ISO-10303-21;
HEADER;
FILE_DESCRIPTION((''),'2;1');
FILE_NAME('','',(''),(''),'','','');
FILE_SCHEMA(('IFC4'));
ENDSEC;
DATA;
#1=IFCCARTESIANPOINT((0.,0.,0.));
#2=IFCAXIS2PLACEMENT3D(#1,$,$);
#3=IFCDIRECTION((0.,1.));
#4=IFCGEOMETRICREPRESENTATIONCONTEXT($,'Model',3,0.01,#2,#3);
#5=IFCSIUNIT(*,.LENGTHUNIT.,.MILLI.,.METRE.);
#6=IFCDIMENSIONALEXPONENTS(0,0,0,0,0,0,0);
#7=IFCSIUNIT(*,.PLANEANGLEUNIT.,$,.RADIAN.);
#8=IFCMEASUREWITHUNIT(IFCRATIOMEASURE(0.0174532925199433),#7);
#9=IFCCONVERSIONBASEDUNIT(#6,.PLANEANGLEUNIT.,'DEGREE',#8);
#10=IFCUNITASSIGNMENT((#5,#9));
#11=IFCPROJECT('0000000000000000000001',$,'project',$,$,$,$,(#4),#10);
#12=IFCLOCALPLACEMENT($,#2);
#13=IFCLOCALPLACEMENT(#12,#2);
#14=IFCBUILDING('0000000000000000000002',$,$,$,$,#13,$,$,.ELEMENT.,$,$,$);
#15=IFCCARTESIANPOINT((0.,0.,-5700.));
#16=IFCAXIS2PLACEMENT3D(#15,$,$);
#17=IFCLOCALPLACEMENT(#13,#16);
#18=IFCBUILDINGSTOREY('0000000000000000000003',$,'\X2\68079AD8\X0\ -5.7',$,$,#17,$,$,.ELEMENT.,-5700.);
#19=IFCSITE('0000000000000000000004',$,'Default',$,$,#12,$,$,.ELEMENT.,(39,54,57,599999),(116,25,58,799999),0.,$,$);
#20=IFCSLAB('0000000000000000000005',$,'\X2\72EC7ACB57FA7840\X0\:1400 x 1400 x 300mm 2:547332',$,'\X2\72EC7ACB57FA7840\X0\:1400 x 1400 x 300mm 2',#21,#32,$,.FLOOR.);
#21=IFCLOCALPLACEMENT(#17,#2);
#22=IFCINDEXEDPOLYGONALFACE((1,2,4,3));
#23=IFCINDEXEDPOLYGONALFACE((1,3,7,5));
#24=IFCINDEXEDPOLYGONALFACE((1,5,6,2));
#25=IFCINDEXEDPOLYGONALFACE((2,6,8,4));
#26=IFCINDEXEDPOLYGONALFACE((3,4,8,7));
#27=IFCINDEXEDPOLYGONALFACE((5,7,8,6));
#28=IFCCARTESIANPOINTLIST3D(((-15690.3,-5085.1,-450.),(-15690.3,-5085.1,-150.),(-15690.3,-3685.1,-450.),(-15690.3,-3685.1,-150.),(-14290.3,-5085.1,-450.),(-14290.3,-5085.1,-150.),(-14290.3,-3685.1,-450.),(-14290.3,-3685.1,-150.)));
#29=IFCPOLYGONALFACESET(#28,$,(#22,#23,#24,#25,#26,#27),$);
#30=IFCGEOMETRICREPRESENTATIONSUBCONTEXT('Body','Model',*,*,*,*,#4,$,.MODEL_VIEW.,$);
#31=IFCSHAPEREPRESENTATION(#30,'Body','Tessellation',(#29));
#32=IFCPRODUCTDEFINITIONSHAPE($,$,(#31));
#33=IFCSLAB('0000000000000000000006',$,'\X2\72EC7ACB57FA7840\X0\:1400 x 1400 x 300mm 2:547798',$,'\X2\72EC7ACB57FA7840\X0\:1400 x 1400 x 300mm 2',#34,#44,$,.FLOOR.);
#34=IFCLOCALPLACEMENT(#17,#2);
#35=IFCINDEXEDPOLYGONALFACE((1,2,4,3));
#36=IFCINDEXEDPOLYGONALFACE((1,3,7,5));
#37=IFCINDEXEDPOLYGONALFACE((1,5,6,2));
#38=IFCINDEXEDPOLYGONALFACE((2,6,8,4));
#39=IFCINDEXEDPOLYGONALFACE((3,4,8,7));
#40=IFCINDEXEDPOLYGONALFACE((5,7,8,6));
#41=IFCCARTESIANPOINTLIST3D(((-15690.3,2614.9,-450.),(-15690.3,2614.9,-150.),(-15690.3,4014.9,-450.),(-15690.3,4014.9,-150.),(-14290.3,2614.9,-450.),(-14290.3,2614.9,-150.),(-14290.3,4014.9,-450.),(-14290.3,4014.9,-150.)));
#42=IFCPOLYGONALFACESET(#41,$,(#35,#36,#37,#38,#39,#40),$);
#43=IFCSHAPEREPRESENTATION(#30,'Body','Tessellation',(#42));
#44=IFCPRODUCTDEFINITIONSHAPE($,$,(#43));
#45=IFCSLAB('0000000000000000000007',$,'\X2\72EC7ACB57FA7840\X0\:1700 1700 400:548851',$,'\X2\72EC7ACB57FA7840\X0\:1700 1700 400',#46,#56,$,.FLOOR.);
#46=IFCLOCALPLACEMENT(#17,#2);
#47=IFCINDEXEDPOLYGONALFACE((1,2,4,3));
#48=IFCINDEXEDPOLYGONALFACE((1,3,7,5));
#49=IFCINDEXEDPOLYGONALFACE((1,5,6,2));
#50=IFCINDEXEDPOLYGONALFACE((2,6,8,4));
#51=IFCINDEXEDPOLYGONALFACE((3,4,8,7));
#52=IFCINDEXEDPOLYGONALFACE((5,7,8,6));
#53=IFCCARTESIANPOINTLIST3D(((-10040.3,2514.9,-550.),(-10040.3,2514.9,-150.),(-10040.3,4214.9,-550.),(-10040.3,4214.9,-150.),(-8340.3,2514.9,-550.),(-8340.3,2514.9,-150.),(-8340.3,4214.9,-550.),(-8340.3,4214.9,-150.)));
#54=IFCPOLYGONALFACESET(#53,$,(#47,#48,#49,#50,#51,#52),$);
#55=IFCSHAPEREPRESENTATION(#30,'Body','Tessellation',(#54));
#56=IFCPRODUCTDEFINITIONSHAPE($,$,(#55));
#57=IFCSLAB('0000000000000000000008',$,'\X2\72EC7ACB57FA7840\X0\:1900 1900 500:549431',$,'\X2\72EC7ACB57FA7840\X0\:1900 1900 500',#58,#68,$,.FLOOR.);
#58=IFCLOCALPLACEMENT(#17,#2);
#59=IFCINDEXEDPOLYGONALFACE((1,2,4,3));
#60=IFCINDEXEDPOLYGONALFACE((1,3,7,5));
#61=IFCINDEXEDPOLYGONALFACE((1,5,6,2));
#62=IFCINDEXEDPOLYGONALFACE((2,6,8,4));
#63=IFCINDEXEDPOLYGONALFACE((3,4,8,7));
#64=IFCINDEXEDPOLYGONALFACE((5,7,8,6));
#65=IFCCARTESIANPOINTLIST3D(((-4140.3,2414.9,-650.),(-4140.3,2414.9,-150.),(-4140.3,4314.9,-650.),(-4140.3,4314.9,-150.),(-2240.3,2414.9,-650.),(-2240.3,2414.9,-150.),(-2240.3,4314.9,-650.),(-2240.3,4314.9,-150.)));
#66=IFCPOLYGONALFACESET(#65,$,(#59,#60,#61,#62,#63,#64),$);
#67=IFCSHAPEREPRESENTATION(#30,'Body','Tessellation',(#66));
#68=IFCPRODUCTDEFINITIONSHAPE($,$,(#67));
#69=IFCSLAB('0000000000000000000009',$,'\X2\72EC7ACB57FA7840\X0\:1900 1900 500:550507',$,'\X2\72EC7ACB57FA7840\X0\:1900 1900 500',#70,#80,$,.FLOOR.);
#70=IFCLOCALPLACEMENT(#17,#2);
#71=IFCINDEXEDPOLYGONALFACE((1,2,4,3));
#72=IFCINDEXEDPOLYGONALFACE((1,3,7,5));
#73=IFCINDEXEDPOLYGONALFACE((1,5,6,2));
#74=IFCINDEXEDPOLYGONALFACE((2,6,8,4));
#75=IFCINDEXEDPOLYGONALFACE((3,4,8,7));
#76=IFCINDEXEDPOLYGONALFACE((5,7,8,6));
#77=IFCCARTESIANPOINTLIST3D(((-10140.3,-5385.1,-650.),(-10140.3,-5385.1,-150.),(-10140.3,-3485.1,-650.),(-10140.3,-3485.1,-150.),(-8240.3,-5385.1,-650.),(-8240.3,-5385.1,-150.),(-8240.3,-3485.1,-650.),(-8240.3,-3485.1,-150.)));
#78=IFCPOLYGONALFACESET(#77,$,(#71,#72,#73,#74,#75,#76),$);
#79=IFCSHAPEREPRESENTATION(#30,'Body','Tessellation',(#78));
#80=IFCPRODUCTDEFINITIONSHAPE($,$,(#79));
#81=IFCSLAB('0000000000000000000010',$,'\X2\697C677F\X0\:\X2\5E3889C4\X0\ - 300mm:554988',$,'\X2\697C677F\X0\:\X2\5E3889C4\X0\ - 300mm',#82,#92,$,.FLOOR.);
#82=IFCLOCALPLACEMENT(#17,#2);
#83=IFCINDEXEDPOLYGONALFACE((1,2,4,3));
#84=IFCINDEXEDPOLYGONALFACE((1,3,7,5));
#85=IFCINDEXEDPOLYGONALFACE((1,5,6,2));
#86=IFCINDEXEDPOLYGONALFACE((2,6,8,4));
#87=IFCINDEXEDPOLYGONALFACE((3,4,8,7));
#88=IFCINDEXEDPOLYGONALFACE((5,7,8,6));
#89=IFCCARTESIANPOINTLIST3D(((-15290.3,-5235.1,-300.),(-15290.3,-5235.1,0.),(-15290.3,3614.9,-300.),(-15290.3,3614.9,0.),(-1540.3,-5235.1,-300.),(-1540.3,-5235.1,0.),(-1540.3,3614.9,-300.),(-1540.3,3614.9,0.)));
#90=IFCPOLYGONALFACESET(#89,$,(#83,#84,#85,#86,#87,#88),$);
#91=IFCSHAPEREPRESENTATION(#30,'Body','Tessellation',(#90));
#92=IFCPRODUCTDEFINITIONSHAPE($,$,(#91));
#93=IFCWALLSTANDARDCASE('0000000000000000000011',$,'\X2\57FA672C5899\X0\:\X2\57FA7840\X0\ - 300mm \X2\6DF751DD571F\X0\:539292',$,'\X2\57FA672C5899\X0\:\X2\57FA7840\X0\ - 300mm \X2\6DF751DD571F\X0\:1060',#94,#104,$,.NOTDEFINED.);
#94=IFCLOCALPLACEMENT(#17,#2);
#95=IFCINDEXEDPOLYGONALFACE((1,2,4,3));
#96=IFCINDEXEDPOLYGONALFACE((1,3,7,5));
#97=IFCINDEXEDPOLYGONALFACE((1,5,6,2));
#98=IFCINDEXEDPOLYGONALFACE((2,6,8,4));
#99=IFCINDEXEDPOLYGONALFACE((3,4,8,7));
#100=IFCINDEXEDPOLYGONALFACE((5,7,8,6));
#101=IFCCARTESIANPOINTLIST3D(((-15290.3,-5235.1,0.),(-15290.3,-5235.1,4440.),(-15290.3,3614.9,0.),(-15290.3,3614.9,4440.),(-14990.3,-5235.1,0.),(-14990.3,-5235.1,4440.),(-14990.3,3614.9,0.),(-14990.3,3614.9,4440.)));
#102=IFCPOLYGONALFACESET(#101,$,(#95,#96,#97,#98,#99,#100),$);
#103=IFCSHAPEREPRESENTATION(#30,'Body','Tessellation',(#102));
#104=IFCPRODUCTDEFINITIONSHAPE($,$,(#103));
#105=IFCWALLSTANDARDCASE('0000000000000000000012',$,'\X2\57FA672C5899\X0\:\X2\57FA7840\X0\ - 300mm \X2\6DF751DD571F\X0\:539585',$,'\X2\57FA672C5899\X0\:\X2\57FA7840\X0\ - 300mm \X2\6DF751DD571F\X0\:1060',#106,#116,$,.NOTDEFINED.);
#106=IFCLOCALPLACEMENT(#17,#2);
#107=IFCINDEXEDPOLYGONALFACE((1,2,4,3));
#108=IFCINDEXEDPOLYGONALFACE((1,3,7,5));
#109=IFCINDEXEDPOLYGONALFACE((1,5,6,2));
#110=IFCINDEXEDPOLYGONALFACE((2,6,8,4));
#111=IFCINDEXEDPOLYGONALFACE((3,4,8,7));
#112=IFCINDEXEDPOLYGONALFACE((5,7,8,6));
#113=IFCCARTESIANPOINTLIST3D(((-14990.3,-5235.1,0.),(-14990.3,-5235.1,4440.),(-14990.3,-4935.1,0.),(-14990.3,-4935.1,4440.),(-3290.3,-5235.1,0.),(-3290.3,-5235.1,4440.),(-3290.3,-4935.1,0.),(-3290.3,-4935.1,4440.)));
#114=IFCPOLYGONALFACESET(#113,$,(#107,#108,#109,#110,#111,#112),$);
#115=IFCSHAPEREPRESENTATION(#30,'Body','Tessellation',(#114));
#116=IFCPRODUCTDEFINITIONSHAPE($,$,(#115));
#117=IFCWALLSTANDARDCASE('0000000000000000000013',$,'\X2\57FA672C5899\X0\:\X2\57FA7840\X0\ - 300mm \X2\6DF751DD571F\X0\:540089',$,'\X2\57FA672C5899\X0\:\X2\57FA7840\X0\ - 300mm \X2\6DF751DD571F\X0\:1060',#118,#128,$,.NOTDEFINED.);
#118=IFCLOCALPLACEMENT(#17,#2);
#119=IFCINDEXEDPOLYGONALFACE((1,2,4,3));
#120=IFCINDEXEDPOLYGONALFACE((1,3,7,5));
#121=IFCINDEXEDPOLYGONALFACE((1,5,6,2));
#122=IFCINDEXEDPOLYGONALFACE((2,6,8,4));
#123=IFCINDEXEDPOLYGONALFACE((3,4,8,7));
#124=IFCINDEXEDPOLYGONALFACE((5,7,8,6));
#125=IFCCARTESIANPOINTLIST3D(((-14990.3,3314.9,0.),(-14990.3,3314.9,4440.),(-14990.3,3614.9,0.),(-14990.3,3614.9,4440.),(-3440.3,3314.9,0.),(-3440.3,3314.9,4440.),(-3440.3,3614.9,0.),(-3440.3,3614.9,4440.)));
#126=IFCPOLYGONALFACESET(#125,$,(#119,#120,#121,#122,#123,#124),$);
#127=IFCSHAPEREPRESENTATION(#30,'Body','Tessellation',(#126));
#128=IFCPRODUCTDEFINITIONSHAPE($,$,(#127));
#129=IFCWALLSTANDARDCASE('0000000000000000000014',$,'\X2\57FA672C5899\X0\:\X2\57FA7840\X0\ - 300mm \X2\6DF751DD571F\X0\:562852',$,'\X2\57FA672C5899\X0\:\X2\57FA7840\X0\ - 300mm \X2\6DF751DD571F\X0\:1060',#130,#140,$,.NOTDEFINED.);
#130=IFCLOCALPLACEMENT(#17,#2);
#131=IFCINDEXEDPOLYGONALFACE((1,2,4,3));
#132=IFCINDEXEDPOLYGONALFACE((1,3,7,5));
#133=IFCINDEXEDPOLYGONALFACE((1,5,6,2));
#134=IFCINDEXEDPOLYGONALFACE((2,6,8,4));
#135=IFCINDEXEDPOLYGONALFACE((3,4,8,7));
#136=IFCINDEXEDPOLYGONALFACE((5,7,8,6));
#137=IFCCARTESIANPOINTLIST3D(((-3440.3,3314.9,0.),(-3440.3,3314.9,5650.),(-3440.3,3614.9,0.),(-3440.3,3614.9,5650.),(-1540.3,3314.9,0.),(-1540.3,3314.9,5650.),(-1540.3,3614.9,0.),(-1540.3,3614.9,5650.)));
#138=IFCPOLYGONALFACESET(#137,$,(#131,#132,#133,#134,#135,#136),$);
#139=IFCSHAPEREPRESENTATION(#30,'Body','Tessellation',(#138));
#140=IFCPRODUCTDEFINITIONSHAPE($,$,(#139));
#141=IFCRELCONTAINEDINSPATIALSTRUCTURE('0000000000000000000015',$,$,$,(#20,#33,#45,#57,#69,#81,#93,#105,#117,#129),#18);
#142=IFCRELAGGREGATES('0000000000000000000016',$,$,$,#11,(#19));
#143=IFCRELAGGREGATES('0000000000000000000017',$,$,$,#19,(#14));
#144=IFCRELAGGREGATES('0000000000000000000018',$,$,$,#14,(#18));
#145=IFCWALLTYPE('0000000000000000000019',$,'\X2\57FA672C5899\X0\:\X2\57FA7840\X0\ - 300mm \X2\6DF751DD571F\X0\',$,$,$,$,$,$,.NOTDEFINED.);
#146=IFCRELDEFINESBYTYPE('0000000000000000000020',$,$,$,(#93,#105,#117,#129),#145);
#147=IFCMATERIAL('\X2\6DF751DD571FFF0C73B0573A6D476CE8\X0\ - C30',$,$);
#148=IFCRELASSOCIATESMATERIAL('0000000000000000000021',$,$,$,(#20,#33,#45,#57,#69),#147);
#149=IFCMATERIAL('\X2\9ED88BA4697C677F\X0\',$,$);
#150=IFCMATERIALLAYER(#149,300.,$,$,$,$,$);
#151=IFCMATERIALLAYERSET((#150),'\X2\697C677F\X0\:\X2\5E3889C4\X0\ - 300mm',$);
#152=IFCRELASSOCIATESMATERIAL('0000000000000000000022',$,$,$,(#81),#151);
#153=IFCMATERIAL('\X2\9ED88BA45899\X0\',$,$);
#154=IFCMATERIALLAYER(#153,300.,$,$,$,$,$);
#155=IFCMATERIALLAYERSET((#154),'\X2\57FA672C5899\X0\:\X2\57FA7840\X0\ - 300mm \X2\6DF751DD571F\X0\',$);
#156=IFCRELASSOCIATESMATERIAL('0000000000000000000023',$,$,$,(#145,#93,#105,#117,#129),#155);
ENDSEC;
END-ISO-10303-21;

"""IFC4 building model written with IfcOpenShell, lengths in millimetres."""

from ifc_helpers import new_model, entity, si_unit, converted_unit, direction, frame, frame_2d, origin, origin_2d_with_axis, place, context, subcontext, project, spatial, polyline, rectangle, extrude, clip, bounded_halfspace, material, layer, layer_set, layer_usage, type_object, element, save


model = new_model("IFC4")

# Units and contexts
model_context = context("Model", 3, precision=0.01, world=origin(), true_north=direction((0.0, 1.0)))
body_context = subcontext(model_context, "Body", "Model", "MODEL_VIEW")
ifc_project = project(units=[si_unit("LENGTHUNIT", "METRE", prefix="MILLI"), converted_unit("PLANEANGLEUNIT", "DEGREE", entity("IfcRatioMeasure", 0.0174532925199433), si_unit("PLANEANGLEUNIT", "RADIAN"), dimensions=[0, 0, 0, 0, 0, 0, 0])], contexts=[model_context])

# Site, building, storey
site_placement = place(None, origin())
site = spatial("IfcSite", under=ifc_project, at=site_placement, Name="Default", CompositionType="ELEMENT", RefLatitude=(39, 54, 57, 599999), RefLongitude=(116, 25, 58, 799999), RefElevation=0.0)
building_placement = place(site_placement, origin())
building = spatial("IfcBuilding", under=site, at=building_placement, CompositionType="ELEMENT")
storey_placement = place(building_placement, frame((0.0, 0.0, -5700.0)))
storey = spatial("IfcBuildingStorey", under=building, at=storey_placement, Name="标高 -5.7", CompositionType="ELEMENT", Elevation=-5700.0)

# Slabs
ifc_material_1 = material(Name="混凝土，现场浇注 - C30")
slab_1_placement = place(storey_placement, frame((-15690.3, -5085.1, -450.0)))
element("IfcSlab", 1, at=slab_1_placement, inside=storey, material=ifc_material_1, Name="独立基础:1400 x 1400 x 300mm 2:547332", ObjectType="独立基础:1400 x 1400 x 300mm 2", PredefinedType="FLOOR", context=body_context, shape_type="SweptSolid", body=[
    extrude(rectangle(XDim=1400.0, YDim=1400.0, at=frame_2d((0.0, 0.0), x_axis=(1.0, 0.0))), frame((700.0, 700.0, 0.0), z_axis=(0.0, 0.0, 1.0), x_axis=(-1.0, 0.0, 0.0)), (0.0, 0.0, 1.0), 300.0),
])
slab_2_placement = place(storey_placement, frame((-15690.3, 2614.9, -450.0)))
element("IfcSlab", 2, at=slab_2_placement, inside=storey, material=ifc_material_1, Name="独立基础:1400 x 1400 x 300mm 2:547798", ObjectType="独立基础:1400 x 1400 x 300mm 2", PredefinedType="FLOOR", context=body_context, shape_type="SweptSolid", body=[
    extrude(rectangle(XDim=1400.0, YDim=1400.0, at=frame_2d((0.0, 0.0), x_axis=(1.0, 0.0))), frame((700.0, 700.0, 0.0), z_axis=(0.0, 0.0, 1.0), x_axis=(-1.0, 0.0, 0.0)), (0.0, 0.0, 1.0), 300.0),
])
slab_3_placement = place(storey_placement, frame((-10040.3, 2514.9, -550.0)))
element("IfcSlab", 3, at=slab_3_placement, inside=storey, material=ifc_material_1, Name="独立基础:1700 1700 400:548851", ObjectType="独立基础:1700 1700 400", PredefinedType="FLOOR", context=body_context, shape_type="SweptSolid", body=[
    extrude(rectangle(XDim=1700.0, YDim=1700.0, at=frame_2d((0.0, 0.0), x_axis=(1.0, 0.0))), frame((850.0, 850.0, 0.0), z_axis=(0.0, 0.0, 1.0), x_axis=(-1.0, 0.0, 0.0)), (0.0, 0.0, 1.0), 400.0),
])
slab_4_placement = place(storey_placement, frame((-4140.3, 2414.9, -650.0)))
element("IfcSlab", 4, at=slab_4_placement, inside=storey, material=ifc_material_1, Name="独立基础:1900 1900 500:549431", ObjectType="独立基础:1900 1900 500", PredefinedType="FLOOR", context=body_context, shape_type="SweptSolid", body=[
    extrude(rectangle(XDim=1900.0, YDim=1900.0, at=frame_2d((0.0, 0.0), x_axis=(1.0, 0.0))), frame((950.0, 950.0, 0.0), z_axis=(0.0, 0.0, 1.0), x_axis=(-1.0, 0.0, 0.0)), (0.0, 0.0, 1.0), 500.0),
])
slab_5_placement = place(storey_placement, frame((-10140.3, -5385.1, -650.0)))
element("IfcSlab", 5, at=slab_5_placement, inside=storey, material=ifc_material_1, Name="独立基础:1900 1900 500:550507", ObjectType="独立基础:1900 1900 500", PredefinedType="FLOOR", context=body_context, shape_type="SweptSolid", body=[
    extrude(rectangle(XDim=1900.0, YDim=1900.0, at=frame_2d((0.0, 0.0), x_axis=(1.0, 0.0))), frame((950.0, 950.0, 0.0), z_axis=(0.0, 0.0, 1.0), x_axis=(-1.0, 0.0, 0.0)), (0.0, 0.0, 1.0), 500.0),
])
ifc_material_2 = material(Name="默认楼板")
ifc_layer_1 = layer(ifc_material_2, 300.0)
ifc_layer_set_1 = layer_set([ifc_layer_1], Name="楼板:常规 - 300mm")
ifc_layer_usage_1 = layer_usage(ifc_layer_set_1, "AXIS3", "POSITIVE", 0.0)
slab_6_placement = place(storey_placement, origin())
element("IfcSlab", 6, at=slab_6_placement, inside=storey, material=ifc_layer_usage_1, Name="楼板:常规 - 300mm:554988", ObjectType="楼板:常规 - 300mm", PredefinedType="FLOOR", context=body_context, shape_type="SweptSolid", body=[
    extrude(rectangle(XDim=8850.0, YDim=13750.0, at=origin_2d_with_axis()), frame((-8415.3, -810.1, 0.0), z_axis=(0.0, 0.0, -1.0), x_axis=(0.0, 1.0, 0.0)), (0.0, 0.0, 1.0), 300.0),
])

# Walls
ifc_material_3 = material(Name="默认墙")
ifc_layer_2 = layer(ifc_material_3, 300.0)
ifc_layer_set_2 = layer_set([ifc_layer_2], Name="基本墙:基础 - 300mm 混凝土")
ifc_layer_usage_2 = layer_usage(ifc_layer_set_2, "AXIS2", "NEGATIVE", 150.0)
wall_type = type_object("IfcWallType", Name="基本墙:基础 - 300mm 混凝土", PredefinedType="NOTDEFINED", material=ifc_layer_set_2)
wall_1_placement = place(storey_placement, frame((-15140.3, 3614.9, 0.0), z_axis=(0.0, 0.0, 1.0), x_axis=(0.0, -1.0, 0.0)))
element("IfcWallStandardCase", 7, at=wall_1_placement, inside=storey, type_object=wall_type, material=ifc_layer_usage_2, Name="基本墙:基础 - 300mm 混凝土:539292", ObjectType="基本墙:基础 - 300mm 混凝土:1060", PredefinedType="NOTDEFINED", context=body_context, shape_type="Clipping", body=[
    clip(extrude(rectangle(XDim=8850.0, YDim=300.0, at=frame_2d((4425.0, 0.0), x_axis=(-1.0, 0.0))), origin(), (0.0, 0.0, 1.0), 4440.0), bounded_halfspace(frame((0.0, -150.0, 4440.0), z_axis=(0.0, 0.0, -1.0), x_axis=(-1.0, 0.0, 0.0)), True, frame((0.0, -150.0, 4440.0)), polyline([(0.0, 0.0), (8800.0, 0.0), (8800.0, 300.0), (8550.0, 300.0), (8300.0, 300.0), (7700.0, 300.0), (600.0, 300.0), (300.0, 300.0), (0.0, 300.0), (0.0, 0.0)]))),
])
ifc_layer_usage_3 = layer_usage(ifc_layer_set_2, "AXIS2", "NEGATIVE", 150.0)
wall_2_placement = place(storey_placement, frame((-14990.3, -5085.1, 0.0)))
element("IfcWallStandardCase", 8, at=wall_2_placement, inside=storey, type_object=wall_type, material=ifc_layer_usage_3, Name="基本墙:基础 - 300mm 混凝土:539585", ObjectType="基本墙:基础 - 300mm 混凝土:1060", PredefinedType="NOTDEFINED", context=body_context, shape_type="Clipping", body=[
    clip(extrude(rectangle(XDim=11700.0, YDim=300.0, at=frame_2d((5850.0, 0.0), x_axis=(-1.0, 0.0))), origin(), (0.0, 0.0, 1.0), 4440.0), bounded_halfspace(frame((11700.0, -100.0, 4440.0), z_axis=(0.0, 0.0, -1.0), x_axis=(0.0, 1.0, 0.0)), True, frame((11700.0, -100.0, 4440.0)), polyline([(0.0, 0.0), (0.0, 250.0), (-11700.0, 250.0), (-11700.0, 0.0), (0.0, 0.0)]))),
])
ifc_layer_usage_4 = layer_usage(ifc_layer_set_2, "AXIS2", "NEGATIVE", 150.0)
wall_3_placement = place(storey_placement, frame((-3440.3, 3464.9, 0.0), z_axis=(0.0, 0.0, 1.0), x_axis=(-1.0, 0.0, 0.0)))
element("IfcWallStandardCase", 9, at=wall_3_placement, inside=storey, type_object=wall_type, material=ifc_layer_usage_4, Name="基本墙:基础 - 300mm 混凝土:540089", ObjectType="基本墙:基础 - 300mm 混凝土:1060", PredefinedType="NOTDEFINED", context=body_context, shape_type="Clipping", body=[
    clip(extrude(rectangle(XDim=11550.0, YDim=300.0, at=frame_2d((5775.0, 0.0), x_axis=(-1.0, 0.0))), origin(), (0.0, 0.0, 1.0), 4440.0), bounded_halfspace(frame((0.0, -150.0, 4440.0), z_axis=(0.0, 0.0, -1.0), x_axis=(0.0, -1.0, 0.0)), True, frame((0.0, -150.0, 4440.0)), polyline([(0.0, 0.0), (11550.0, 0.0), (11550.0, 300.0), (11250.0, 300.0), (6000.0, 300.0), (5500.0, 300.0), (0.0, 300.0), (0.0, 0.0)]))),
])
ifc_layer_usage_5 = layer_usage(ifc_layer_set_2, "AXIS2", "NEGATIVE", 150.0)
wall_4_placement = place(storey_placement, frame((-3440.3, 3464.9, 0.0)))
element("IfcWallStandardCase", 10, at=wall_4_placement, inside=storey, type_object=wall_type, material=ifc_layer_usage_5, Name="基本墙:基础 - 300mm 混凝土:562852", ObjectType="基本墙:基础 - 300mm 混凝土:1060", PredefinedType="NOTDEFINED", context=body_context, shape_type="SweptSolid", body=[
    extrude(rectangle(XDim=1900.0, YDim=300.0, at=frame_2d((950.0, 0.0), x_axis=(-1.0, 0.0))), origin(), (0.0, 0.0, 1.0), 5650.0),
])

save(model, "model.ifc")
